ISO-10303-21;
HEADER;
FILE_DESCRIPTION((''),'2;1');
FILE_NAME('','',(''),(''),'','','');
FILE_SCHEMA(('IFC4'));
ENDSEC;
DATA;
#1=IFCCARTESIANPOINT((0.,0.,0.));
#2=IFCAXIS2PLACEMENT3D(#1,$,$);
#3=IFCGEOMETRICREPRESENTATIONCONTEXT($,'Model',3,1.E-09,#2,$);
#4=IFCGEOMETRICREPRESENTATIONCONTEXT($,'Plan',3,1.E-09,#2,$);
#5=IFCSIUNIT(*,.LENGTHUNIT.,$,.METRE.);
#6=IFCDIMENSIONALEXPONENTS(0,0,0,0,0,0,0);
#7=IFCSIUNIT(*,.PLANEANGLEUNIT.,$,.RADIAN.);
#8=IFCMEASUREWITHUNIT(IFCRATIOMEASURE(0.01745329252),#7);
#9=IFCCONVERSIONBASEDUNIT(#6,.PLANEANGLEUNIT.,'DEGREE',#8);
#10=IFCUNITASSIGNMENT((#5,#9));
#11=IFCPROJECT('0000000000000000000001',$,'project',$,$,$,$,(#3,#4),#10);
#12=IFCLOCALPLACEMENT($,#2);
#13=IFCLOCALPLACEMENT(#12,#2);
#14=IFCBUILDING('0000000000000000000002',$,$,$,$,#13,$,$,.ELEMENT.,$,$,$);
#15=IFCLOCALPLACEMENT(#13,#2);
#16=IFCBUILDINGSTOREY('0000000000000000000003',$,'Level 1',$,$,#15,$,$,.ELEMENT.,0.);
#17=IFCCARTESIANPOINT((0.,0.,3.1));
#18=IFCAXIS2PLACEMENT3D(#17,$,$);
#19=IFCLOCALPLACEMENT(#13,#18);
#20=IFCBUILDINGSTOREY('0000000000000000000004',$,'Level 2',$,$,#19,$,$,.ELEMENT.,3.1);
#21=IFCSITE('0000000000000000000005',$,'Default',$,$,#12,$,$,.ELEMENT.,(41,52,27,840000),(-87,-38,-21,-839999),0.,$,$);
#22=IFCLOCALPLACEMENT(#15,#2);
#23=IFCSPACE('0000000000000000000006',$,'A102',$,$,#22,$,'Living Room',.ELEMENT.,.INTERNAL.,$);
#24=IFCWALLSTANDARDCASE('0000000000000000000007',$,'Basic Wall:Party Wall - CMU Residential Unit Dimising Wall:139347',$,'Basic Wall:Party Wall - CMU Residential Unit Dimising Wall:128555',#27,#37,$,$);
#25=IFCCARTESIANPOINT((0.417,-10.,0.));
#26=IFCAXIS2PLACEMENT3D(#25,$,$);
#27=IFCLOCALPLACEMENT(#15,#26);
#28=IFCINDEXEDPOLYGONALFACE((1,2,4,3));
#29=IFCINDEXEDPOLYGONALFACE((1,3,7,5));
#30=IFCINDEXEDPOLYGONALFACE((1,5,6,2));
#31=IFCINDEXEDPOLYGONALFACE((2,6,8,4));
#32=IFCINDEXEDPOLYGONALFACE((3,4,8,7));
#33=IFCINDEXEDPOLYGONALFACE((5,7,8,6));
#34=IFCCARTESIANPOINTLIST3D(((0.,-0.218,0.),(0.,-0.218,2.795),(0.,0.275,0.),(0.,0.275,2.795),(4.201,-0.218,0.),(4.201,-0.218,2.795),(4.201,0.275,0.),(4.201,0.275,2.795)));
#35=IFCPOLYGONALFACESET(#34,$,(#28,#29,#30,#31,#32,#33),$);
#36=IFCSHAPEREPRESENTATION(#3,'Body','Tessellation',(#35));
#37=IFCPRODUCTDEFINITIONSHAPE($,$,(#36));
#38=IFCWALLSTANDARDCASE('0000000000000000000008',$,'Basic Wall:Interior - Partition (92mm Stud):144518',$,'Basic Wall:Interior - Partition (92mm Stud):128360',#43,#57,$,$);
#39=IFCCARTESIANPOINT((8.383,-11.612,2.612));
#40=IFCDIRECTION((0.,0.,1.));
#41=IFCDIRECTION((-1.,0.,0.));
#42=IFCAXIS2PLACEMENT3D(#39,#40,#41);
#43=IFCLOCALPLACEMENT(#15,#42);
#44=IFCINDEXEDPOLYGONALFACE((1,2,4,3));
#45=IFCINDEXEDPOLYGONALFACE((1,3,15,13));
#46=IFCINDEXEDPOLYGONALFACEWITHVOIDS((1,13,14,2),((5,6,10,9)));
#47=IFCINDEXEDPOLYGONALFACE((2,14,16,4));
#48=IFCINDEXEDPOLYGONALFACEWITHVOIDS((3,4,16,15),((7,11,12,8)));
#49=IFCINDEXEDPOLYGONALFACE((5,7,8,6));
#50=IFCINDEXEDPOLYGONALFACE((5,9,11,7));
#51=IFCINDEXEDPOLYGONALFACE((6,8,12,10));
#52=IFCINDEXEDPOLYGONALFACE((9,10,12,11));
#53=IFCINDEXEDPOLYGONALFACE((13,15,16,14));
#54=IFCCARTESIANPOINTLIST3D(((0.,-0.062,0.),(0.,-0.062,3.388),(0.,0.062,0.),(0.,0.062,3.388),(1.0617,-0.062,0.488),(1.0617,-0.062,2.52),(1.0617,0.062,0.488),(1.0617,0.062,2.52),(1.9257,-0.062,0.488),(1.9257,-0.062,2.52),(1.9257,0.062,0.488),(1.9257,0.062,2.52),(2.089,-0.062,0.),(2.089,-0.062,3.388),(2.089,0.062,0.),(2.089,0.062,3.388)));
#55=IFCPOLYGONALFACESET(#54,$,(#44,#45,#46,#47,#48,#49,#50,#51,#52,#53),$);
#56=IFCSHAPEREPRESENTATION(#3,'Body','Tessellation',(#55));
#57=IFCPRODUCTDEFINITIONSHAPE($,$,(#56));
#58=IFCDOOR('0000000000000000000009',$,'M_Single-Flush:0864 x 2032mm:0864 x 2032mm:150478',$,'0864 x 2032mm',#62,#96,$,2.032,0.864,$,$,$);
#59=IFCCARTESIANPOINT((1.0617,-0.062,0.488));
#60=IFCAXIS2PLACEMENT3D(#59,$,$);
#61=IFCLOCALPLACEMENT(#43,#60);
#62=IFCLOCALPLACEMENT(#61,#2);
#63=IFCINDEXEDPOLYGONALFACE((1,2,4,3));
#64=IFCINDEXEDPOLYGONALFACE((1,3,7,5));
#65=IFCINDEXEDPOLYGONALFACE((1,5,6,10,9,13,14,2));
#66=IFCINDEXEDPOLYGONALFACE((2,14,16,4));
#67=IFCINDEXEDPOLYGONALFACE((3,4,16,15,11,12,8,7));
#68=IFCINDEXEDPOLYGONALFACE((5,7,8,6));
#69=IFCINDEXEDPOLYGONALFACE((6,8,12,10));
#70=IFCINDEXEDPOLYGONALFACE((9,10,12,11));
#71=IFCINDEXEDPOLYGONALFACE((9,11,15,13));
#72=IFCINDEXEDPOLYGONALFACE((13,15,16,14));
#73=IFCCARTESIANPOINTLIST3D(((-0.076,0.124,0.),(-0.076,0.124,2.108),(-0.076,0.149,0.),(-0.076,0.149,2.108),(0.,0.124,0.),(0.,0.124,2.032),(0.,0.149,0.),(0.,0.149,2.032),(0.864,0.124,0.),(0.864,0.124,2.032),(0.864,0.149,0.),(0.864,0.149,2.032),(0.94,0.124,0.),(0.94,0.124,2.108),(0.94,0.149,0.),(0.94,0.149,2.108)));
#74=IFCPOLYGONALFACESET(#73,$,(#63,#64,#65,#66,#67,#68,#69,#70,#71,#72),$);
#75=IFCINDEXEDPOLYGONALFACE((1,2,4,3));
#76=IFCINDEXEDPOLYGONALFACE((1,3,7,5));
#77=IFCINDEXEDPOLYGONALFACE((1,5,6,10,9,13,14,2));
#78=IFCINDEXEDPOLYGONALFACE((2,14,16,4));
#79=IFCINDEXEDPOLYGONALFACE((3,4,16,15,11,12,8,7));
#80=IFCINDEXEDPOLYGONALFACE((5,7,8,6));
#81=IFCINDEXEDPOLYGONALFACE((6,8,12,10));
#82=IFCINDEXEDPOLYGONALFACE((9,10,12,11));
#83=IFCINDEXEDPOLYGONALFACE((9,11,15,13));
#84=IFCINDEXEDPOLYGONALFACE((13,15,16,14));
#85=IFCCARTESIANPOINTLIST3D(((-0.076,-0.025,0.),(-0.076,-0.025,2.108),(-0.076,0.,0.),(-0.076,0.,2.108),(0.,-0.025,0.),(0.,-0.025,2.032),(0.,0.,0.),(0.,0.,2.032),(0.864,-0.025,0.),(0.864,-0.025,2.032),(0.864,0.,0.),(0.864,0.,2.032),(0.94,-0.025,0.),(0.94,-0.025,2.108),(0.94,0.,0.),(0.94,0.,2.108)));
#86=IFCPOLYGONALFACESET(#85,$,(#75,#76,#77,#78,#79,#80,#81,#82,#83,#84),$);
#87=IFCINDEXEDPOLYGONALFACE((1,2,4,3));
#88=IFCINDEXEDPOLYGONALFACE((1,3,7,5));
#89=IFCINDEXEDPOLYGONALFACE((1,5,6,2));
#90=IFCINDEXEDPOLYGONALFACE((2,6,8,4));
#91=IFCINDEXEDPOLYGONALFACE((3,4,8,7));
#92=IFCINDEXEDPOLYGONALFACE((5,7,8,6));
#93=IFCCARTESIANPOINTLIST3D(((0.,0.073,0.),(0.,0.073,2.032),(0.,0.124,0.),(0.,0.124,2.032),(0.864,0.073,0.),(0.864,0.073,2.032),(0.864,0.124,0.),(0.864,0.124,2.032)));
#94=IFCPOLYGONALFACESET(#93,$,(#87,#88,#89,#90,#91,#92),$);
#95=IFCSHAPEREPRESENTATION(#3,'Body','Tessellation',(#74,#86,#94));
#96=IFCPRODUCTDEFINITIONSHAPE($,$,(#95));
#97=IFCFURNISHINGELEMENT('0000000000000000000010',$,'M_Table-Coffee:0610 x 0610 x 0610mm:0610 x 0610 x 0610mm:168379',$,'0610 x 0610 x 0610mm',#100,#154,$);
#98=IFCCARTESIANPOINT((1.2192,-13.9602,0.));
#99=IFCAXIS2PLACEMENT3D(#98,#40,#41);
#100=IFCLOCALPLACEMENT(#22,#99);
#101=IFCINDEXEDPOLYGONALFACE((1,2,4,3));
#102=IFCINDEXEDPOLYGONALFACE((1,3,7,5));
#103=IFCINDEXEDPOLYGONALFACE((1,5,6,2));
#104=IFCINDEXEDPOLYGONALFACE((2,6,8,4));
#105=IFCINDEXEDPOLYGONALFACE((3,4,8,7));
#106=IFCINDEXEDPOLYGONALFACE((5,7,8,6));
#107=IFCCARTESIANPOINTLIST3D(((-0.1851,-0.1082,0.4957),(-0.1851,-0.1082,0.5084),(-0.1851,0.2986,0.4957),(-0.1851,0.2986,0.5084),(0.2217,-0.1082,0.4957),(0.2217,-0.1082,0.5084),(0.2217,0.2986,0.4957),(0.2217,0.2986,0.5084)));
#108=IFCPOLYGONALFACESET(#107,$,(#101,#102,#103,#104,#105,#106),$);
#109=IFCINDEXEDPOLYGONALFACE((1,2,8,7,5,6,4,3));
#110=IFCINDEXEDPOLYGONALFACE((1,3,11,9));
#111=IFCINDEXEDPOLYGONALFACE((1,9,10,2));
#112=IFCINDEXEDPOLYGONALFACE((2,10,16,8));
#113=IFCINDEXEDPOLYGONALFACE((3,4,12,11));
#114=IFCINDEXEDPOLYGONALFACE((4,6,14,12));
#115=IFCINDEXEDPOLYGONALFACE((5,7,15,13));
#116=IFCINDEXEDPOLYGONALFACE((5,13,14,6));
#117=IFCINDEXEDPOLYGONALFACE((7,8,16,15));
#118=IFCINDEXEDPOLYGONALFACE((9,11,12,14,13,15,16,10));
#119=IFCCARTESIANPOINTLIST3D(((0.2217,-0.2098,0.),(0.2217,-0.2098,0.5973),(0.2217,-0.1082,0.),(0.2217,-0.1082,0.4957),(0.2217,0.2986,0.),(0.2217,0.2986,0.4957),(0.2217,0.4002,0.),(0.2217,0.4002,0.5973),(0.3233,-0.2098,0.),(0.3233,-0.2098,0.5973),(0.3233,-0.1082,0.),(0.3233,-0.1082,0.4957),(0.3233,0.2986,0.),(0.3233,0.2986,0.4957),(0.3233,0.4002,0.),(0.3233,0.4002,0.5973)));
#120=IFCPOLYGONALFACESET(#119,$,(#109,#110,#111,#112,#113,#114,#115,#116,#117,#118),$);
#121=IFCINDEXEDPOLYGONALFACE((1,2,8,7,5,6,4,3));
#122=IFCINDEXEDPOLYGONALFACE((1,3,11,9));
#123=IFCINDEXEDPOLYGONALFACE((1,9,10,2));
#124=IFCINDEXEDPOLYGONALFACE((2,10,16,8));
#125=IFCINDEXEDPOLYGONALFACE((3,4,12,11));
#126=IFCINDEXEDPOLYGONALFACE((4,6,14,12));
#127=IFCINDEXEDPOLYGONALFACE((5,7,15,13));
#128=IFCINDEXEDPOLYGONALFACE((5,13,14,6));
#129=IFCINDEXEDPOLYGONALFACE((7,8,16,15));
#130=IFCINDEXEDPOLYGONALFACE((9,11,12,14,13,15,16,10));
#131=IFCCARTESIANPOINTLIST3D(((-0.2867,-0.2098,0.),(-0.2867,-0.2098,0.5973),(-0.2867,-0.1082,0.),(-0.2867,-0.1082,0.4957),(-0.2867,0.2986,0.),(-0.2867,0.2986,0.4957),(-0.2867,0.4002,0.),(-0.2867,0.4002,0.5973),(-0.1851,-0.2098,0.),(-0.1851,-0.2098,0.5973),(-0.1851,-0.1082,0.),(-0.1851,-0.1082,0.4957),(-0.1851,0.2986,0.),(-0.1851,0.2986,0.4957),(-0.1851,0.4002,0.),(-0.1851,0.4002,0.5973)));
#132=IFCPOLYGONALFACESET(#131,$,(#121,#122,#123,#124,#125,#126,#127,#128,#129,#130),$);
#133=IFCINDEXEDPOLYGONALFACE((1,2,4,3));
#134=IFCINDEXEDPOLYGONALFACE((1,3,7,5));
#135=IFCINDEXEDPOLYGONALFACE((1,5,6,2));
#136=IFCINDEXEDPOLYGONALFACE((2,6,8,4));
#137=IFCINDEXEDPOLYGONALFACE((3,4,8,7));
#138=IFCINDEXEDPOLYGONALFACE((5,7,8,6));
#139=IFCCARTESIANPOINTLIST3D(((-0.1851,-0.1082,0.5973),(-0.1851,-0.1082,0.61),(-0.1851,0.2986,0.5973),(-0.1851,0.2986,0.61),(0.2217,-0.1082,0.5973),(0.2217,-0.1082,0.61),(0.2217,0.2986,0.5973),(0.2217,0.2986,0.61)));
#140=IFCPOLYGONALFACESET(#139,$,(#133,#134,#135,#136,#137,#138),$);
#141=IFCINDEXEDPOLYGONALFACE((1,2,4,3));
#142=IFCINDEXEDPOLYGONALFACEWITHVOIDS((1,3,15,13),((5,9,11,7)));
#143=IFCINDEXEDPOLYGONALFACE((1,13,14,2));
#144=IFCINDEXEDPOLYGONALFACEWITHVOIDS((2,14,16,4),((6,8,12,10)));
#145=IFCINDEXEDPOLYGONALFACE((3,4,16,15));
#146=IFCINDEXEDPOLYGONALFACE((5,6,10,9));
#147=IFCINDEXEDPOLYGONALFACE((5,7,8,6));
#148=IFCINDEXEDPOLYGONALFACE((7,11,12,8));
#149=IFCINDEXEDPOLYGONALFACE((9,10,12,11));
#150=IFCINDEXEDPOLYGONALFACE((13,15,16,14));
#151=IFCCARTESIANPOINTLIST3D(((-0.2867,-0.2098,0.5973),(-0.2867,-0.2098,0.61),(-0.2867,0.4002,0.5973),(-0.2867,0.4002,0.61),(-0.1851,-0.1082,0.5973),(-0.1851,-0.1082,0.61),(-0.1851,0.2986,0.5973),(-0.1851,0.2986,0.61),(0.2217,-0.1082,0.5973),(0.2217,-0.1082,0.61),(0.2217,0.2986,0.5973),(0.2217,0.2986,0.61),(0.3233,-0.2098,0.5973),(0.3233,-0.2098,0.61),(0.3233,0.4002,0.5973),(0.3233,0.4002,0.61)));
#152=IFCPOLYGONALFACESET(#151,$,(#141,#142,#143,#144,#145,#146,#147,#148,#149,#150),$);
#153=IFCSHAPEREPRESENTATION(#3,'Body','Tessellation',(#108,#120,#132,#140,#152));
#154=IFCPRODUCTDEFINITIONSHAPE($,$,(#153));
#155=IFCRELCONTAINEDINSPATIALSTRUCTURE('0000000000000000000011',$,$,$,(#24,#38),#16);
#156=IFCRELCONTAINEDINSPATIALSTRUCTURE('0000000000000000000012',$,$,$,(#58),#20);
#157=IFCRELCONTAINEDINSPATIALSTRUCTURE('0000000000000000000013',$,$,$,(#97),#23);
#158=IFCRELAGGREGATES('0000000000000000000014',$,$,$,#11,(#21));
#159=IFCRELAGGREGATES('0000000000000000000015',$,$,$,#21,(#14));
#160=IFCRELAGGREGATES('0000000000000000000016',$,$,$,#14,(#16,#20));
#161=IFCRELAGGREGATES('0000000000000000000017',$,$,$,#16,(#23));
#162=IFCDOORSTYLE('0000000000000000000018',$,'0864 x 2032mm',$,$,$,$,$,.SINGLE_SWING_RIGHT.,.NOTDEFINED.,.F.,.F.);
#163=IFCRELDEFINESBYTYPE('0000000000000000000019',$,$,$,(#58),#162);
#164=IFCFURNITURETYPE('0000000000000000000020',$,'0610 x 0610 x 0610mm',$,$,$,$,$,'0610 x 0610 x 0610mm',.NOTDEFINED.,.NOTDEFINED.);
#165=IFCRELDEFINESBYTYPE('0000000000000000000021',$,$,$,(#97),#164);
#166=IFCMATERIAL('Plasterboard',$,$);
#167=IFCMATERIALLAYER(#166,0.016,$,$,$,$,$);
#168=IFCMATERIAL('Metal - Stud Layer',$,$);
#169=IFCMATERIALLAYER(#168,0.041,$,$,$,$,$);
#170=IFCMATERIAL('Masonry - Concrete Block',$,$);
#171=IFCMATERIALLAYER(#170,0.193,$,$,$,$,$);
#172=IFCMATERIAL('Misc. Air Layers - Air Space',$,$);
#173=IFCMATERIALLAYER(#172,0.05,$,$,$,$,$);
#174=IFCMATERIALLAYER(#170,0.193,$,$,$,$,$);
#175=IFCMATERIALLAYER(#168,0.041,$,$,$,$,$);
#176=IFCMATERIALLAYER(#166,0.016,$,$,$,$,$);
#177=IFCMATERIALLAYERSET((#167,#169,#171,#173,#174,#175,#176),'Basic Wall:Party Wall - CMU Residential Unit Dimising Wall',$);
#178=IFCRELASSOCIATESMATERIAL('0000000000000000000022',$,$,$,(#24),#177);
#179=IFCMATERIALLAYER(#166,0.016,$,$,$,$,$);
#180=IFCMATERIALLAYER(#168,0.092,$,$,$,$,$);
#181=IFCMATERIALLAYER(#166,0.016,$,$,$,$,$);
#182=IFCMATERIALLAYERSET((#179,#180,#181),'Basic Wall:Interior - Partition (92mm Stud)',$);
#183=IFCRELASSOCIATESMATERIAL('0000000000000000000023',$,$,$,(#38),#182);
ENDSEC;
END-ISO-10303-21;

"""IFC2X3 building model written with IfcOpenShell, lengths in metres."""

from ifc_helpers import new_model, entity, si_unit, converted_unit, frame, frame_2d, origin, origin_2d_with_axis, place, context, project, spatial, polyline, rectangle, outline, extrude, clip, bounded_halfspace, source, transform, mapped, material, layer, layer_set, layer_usage, type_object, type_shapes, element, fill, save


model = new_model("IFC2X3")

# Units and contexts
model_context = context("Model", 3, precision=1e-09, world=origin())
plan_context = context("Plan", 3, precision=1e-09, world=origin())
ifc_project = project(units=[si_unit("LENGTHUNIT", "METRE"), converted_unit("PLANEANGLEUNIT", "DEGREE", entity("IfcRatioMeasure", 0.01745329252), si_unit("PLANEANGLEUNIT", "RADIAN"), dimensions=[0, 0, 0, 0, 0, 0, 0])], contexts=[model_context, plan_context])

# Site, building, storey
site_placement = place(None, origin())
site = spatial("IfcSite", under=ifc_project, at=site_placement, Name="Default", CompositionType="ELEMENT", RefLatitude=(41, 52, 27, 840000), RefLongitude=(-87, -38, -21, -839999), RefElevation=0.0)
building_placement = place(site_placement, origin())
building = spatial("IfcBuilding", under=site, at=building_placement, CompositionType="ELEMENT")
storey_1_placement = place(building_placement, origin())
storey_1 = spatial("IfcBuildingStorey", under=building, at=storey_1_placement, Name="Level 1", CompositionType="ELEMENT", Elevation=0.0)

# Shared definitions
ifc_material_1 = material(Name="Misc. Air Layers - Air Space")
ifc_material_2 = material(Name="Masonry - Concrete Block")
ifc_material_3 = material(Name="Metal - Stud Layer")
ifc_material_4 = material(Name="Plasterboard")

# Wall
ifc_layer_1 = layer(ifc_material_4, 0.016)
ifc_layer_2 = layer(ifc_material_3, 0.041)
ifc_layer_3 = layer(ifc_material_2, 0.193)
ifc_layer_4 = layer(ifc_material_1, 0.05)
ifc_layer_5 = layer(ifc_material_2, 0.193)
ifc_layer_6 = layer(ifc_material_3, 0.041)
ifc_layer_7 = layer(ifc_material_4, 0.016)
ifc_layer_set_1 = layer_set([ifc_layer_1, ifc_layer_2, ifc_layer_3, ifc_layer_4, ifc_layer_5, ifc_layer_6, ifc_layer_7], Name="Basic Wall:Party Wall - CMU Residential Unit Dimising Wall")
ifc_layer_usage_1 = layer_usage(ifc_layer_set_1, "AXIS2", "NEGATIVE", 0.275)
wall_1_placement = place(storey_1_placement, frame((0.417, -10.0, 0.0)))
element("IfcWallStandardCase", 1, at=wall_1_placement, inside=storey_1, material=ifc_layer_usage_1, Name="Basic Wall:Party Wall - CMU Residential Unit Dimising Wall:139347", ObjectType="Basic Wall:Party Wall - CMU Residential Unit Dimising Wall:128555", context=model_context, shape_type="Clipping", body=[
    clip(clip(extrude(rectangle(XDim=4.201, YDim=0.55, at=frame_2d((2.1005, 0.0), x_axis=(-1.0, 0.0))), origin(), (0.0, 0.0, 1.0), 2.795), bounded_halfspace(frame((0.0, -0.218, 0.0), z_axis=(0.0, 1.0, 0.0), x_axis=(-1.0, 0.0, 0.0)), True, frame((0.0, -0.218, 0.0), z_axis=(0.0, 1.0, 0.0), x_axis=(-1.0, 0.0, 0.0)), polyline([(0.0, 0.0), (0.0, 2.795), (-4.201, 2.795), (-4.201, 0.0), (0.0, 0.0)]))), bounded_halfspace(frame((4.201, 0.275, 0.0), z_axis=(-1.0, 0.0, 0.0), x_axis=(0.0, -1.0, 0.0)), True, frame((4.201, 0.275, 0.0), z_axis=(-1.0, 0.0, 0.0), x_axis=(0.0, -1.0, 0.0)), polyline([(0.0, 0.0), (0.493, 0.0), (0.493, 2.795), (0.0, 2.795), (0.0, 0.0)]))),
])

# Shared definitions
ifc_layer_8 = layer(ifc_material_4, 0.016)
ifc_layer_9 = layer(ifc_material_3, 0.092)
ifc_layer_10 = layer(ifc_material_4, 0.016)
ifc_layer_set_2 = layer_set([ifc_layer_8, ifc_layer_9, ifc_layer_10], Name="Basic Wall:Interior - Partition (92mm Stud)")

# Wall, opening
ifc_layer_usage_2 = layer_usage(ifc_layer_set_2, "AXIS2", "NEGATIVE", 0.062)
wall_2_placement = place(storey_1_placement, frame((8.383, -11.612, 2.612), z_axis=(0.0, 0.0, 1.0), x_axis=(-1.0, 0.0, 0.0)))
wall_2 = element("IfcWallStandardCase", 2, at=wall_2_placement, inside=storey_1, material=ifc_layer_usage_2, Name="Basic Wall:Interior - Partition (92mm Stud):144518", ObjectType="Basic Wall:Interior - Partition (92mm Stud):128360", context=model_context, shape_type="SweptSolid", body=[
    extrude(rectangle(XDim=2.089, YDim=0.124, at=frame_2d((1.0445, 0.0), x_axis=(-1.0, 0.0))), origin(), (0.0, 0.0, 1.0), 3.388),
])
opening_1_placement = place(wall_2_placement, frame((1.0617, -0.062, 0.488)))
opening_1 = element("IfcOpeningElement", 3, at=opening_1_placement, cuts=wall_2, ObjectType="Opening", context=model_context, shape_type="SweptSolid", body=[
    extrude(rectangle(XDim=0.864, YDim=2.032, at=frame_2d((1.016, 0.432), x_axis=(0.0, 1.0))), frame((0.0, 0.0, 0.0), z_axis=(0.0, 1.0, 0.0), x_axis=(0.0, 0.0, 1.0)), (0.0, 0.0, 1.0), 0.124),
])

# Shared definitions
storey_2_placement = place(building_placement, frame((0.0, 0.0, 3.1)))
storey_2 = spatial("IfcBuildingStorey", under=building, at=storey_2_placement, Name="Level 2", CompositionType="ELEMENT", Elevation=3.1)

# Door
door_style_1 = type_object("IfcDoorStyle", Name="0864 x 2032mm", ConstructionType="NOTDEFINED", OperationType="SINGLE_SWING_RIGHT", ParameterTakesPrecedence=False, Sizeable=False)
shared_shape_1 = source(origin(), model_context, "Body", "SweptSolid", [
    extrude(outline(polyline([(-0.508, -1.073), (0.508, -1.073), (0.508, 1.035), (0.432, 1.035), (0.432, -0.997), (-0.432, -0.997), (-0.432, 1.035), (-0.508, 1.035), (-0.508, -1.073)])), frame((0.432, 0.124, 1.035), z_axis=(0.0, 1.0, 0.0), x_axis=(1.0, 0.0, 0.0)), (0.0, 0.0, 1.0), 0.025),
    extrude(outline(polyline([(-1.073, -0.508), (1.035, -0.508), (1.035, -0.432), (-0.997, -0.432), (-0.997, 0.432), (1.035, 0.432), (1.035, 0.508), (-1.073, 0.508), (-1.073, -0.508)])), frame((0.432, -0.025, 1.035), z_axis=(0.0, 1.0, 0.0), x_axis=(0.0, 0.0, -1.0)), (0.0, 0.0, 1.0), 0.025),
    extrude(rectangle(XDim=0.051, YDim=0.864, at=origin_2d_with_axis()), frame((0.432, 0.0985, 0.0), z_axis=(0.0, 0.0, 1.0), x_axis=(0.0, 1.0, 0.0)), (0.0, 0.0, 1.0), 2.032),
])
type_shapes(door_style_1, [shared_shape_1])
door_1_placement = place(opening_1_placement, origin())
door_1 = element("IfcDoor", 4, at=door_1_placement, inside=storey_2, type_object=door_style_1, Name="M_Single-Flush:0864 x 2032mm:0864 x 2032mm:150478", ObjectType="0864 x 2032mm", OverallHeight=2.032, OverallWidth=0.864, context=model_context, shape_type="MappedRepresentation", body=[
    mapped(shared_shape_1, transform((0.0, 0.0, 0.0), scale=1.0)),
])
fill(opening_1, door_1)

# Shared definitions
space_1_placement = place(storey_1_placement, origin())
space_1 = spatial("IfcSpace", under=storey_1, at=space_1_placement, Name="A102", LongName="Living Room", CompositionType="ELEMENT", InteriorOrExteriorSpace="INTERNAL")

# Furnishing element
furniture_type_1 = type_object("IfcFurnitureType", Name="0610 x 0610 x 0610mm", ElementType="0610 x 0610 x 0610mm", AssemblyPlace="NOTDEFINED")
shared_shape_2 = source(origin(), model_context, "Body", "SweptSolid", [
    extrude(rectangle(XDim=0.4068, YDim=0.4068, at=origin_2d_with_axis()), frame((0.0183, 0.0952, 0.4957), z_axis=(0.0, 0.0, 1.0), x_axis=(-1.0, 0.0, 0.0)), (0.0, 0.0, 1.0), 0.0127),
    extrude(outline(polyline([(-0.2732, -0.305), (0.3241, -0.305), (0.3241, 0.305), (-0.2732, 0.305), (-0.2732, 0.2034), (0.2225, 0.2034), (0.2225, -0.2034), (-0.2732, -0.2034), (-0.2732, -0.305)])), frame((0.2217, 0.0952, 0.2732), z_axis=(1.0, 0.0, 0.0), x_axis=(0.0, 0.0, 1.0)), (0.0, 0.0, 1.0), 0.1016),
    extrude(outline(polyline([(-0.305, -0.3241), (0.305, -0.3241), (0.305, 0.2732), (0.2034, 0.2732), (0.2034, -0.2225), (-0.2034, -0.2225), (-0.2034, 0.2732), (-0.305, 0.2732), (-0.305, -0.3241)])), frame((-0.2867, 0.0952, 0.2732), z_axis=(1.0, 0.0, 0.0), x_axis=(0.0, -1.0, 0.0)), (0.0, 0.0, 1.0), 0.1016),
    extrude(rectangle(XDim=0.4068, YDim=0.4068, at=origin_2d_with_axis()), frame((0.0183, 0.0952, 0.5973), z_axis=(0.0, 0.0, 1.0), x_axis=(-1.0, 0.0, 0.0)), (0.0, 0.0, 1.0), 0.0127),
    extrude(outline(polyline([(-0.305, -0.305), (0.305, -0.305), (0.305, 0.305), (-0.305, 0.305), (-0.305, -0.305)]), holes=[polyline([(-0.2034, -0.2034), (-0.2034, 0.2034), (0.2034, 0.2034), (0.2034, -0.2034), (-0.2034, -0.2034)])]), frame((0.0183, 0.0952, 0.5973), z_axis=(0.0, 0.0, 1.0), x_axis=(-1.0, 0.0, 0.0)), (0.0, 0.0, 1.0), 0.0127),
])
type_shapes(furniture_type_1, [shared_shape_2])
for number, where, z_axis, x_axis, name in (
    (5, (1.2192, -13.9602, 0.0), (0.0, 0.0, 1.0), (-1.0, 0.0, 0.0), "M_Table-Coffee:0610 x 0610 x 0610mm:0610 x 0610 x 0610mm:168379"),
):
    element("IfcFurnishingElement", number, at=place(space_1_placement, frame(where, z_axis=z_axis, x_axis=x_axis)), inside=space_1, type_object=furniture_type_1, Name=name, ObjectType="0610 x 0610 x 0610mm", context=model_context, shape_type="MappedRepresentation", body=[
        mapped(shared_shape_2, transform((0.0, 0.0, 0.0), scale=1.0)),
    ])

save(model, "model.ifc")
